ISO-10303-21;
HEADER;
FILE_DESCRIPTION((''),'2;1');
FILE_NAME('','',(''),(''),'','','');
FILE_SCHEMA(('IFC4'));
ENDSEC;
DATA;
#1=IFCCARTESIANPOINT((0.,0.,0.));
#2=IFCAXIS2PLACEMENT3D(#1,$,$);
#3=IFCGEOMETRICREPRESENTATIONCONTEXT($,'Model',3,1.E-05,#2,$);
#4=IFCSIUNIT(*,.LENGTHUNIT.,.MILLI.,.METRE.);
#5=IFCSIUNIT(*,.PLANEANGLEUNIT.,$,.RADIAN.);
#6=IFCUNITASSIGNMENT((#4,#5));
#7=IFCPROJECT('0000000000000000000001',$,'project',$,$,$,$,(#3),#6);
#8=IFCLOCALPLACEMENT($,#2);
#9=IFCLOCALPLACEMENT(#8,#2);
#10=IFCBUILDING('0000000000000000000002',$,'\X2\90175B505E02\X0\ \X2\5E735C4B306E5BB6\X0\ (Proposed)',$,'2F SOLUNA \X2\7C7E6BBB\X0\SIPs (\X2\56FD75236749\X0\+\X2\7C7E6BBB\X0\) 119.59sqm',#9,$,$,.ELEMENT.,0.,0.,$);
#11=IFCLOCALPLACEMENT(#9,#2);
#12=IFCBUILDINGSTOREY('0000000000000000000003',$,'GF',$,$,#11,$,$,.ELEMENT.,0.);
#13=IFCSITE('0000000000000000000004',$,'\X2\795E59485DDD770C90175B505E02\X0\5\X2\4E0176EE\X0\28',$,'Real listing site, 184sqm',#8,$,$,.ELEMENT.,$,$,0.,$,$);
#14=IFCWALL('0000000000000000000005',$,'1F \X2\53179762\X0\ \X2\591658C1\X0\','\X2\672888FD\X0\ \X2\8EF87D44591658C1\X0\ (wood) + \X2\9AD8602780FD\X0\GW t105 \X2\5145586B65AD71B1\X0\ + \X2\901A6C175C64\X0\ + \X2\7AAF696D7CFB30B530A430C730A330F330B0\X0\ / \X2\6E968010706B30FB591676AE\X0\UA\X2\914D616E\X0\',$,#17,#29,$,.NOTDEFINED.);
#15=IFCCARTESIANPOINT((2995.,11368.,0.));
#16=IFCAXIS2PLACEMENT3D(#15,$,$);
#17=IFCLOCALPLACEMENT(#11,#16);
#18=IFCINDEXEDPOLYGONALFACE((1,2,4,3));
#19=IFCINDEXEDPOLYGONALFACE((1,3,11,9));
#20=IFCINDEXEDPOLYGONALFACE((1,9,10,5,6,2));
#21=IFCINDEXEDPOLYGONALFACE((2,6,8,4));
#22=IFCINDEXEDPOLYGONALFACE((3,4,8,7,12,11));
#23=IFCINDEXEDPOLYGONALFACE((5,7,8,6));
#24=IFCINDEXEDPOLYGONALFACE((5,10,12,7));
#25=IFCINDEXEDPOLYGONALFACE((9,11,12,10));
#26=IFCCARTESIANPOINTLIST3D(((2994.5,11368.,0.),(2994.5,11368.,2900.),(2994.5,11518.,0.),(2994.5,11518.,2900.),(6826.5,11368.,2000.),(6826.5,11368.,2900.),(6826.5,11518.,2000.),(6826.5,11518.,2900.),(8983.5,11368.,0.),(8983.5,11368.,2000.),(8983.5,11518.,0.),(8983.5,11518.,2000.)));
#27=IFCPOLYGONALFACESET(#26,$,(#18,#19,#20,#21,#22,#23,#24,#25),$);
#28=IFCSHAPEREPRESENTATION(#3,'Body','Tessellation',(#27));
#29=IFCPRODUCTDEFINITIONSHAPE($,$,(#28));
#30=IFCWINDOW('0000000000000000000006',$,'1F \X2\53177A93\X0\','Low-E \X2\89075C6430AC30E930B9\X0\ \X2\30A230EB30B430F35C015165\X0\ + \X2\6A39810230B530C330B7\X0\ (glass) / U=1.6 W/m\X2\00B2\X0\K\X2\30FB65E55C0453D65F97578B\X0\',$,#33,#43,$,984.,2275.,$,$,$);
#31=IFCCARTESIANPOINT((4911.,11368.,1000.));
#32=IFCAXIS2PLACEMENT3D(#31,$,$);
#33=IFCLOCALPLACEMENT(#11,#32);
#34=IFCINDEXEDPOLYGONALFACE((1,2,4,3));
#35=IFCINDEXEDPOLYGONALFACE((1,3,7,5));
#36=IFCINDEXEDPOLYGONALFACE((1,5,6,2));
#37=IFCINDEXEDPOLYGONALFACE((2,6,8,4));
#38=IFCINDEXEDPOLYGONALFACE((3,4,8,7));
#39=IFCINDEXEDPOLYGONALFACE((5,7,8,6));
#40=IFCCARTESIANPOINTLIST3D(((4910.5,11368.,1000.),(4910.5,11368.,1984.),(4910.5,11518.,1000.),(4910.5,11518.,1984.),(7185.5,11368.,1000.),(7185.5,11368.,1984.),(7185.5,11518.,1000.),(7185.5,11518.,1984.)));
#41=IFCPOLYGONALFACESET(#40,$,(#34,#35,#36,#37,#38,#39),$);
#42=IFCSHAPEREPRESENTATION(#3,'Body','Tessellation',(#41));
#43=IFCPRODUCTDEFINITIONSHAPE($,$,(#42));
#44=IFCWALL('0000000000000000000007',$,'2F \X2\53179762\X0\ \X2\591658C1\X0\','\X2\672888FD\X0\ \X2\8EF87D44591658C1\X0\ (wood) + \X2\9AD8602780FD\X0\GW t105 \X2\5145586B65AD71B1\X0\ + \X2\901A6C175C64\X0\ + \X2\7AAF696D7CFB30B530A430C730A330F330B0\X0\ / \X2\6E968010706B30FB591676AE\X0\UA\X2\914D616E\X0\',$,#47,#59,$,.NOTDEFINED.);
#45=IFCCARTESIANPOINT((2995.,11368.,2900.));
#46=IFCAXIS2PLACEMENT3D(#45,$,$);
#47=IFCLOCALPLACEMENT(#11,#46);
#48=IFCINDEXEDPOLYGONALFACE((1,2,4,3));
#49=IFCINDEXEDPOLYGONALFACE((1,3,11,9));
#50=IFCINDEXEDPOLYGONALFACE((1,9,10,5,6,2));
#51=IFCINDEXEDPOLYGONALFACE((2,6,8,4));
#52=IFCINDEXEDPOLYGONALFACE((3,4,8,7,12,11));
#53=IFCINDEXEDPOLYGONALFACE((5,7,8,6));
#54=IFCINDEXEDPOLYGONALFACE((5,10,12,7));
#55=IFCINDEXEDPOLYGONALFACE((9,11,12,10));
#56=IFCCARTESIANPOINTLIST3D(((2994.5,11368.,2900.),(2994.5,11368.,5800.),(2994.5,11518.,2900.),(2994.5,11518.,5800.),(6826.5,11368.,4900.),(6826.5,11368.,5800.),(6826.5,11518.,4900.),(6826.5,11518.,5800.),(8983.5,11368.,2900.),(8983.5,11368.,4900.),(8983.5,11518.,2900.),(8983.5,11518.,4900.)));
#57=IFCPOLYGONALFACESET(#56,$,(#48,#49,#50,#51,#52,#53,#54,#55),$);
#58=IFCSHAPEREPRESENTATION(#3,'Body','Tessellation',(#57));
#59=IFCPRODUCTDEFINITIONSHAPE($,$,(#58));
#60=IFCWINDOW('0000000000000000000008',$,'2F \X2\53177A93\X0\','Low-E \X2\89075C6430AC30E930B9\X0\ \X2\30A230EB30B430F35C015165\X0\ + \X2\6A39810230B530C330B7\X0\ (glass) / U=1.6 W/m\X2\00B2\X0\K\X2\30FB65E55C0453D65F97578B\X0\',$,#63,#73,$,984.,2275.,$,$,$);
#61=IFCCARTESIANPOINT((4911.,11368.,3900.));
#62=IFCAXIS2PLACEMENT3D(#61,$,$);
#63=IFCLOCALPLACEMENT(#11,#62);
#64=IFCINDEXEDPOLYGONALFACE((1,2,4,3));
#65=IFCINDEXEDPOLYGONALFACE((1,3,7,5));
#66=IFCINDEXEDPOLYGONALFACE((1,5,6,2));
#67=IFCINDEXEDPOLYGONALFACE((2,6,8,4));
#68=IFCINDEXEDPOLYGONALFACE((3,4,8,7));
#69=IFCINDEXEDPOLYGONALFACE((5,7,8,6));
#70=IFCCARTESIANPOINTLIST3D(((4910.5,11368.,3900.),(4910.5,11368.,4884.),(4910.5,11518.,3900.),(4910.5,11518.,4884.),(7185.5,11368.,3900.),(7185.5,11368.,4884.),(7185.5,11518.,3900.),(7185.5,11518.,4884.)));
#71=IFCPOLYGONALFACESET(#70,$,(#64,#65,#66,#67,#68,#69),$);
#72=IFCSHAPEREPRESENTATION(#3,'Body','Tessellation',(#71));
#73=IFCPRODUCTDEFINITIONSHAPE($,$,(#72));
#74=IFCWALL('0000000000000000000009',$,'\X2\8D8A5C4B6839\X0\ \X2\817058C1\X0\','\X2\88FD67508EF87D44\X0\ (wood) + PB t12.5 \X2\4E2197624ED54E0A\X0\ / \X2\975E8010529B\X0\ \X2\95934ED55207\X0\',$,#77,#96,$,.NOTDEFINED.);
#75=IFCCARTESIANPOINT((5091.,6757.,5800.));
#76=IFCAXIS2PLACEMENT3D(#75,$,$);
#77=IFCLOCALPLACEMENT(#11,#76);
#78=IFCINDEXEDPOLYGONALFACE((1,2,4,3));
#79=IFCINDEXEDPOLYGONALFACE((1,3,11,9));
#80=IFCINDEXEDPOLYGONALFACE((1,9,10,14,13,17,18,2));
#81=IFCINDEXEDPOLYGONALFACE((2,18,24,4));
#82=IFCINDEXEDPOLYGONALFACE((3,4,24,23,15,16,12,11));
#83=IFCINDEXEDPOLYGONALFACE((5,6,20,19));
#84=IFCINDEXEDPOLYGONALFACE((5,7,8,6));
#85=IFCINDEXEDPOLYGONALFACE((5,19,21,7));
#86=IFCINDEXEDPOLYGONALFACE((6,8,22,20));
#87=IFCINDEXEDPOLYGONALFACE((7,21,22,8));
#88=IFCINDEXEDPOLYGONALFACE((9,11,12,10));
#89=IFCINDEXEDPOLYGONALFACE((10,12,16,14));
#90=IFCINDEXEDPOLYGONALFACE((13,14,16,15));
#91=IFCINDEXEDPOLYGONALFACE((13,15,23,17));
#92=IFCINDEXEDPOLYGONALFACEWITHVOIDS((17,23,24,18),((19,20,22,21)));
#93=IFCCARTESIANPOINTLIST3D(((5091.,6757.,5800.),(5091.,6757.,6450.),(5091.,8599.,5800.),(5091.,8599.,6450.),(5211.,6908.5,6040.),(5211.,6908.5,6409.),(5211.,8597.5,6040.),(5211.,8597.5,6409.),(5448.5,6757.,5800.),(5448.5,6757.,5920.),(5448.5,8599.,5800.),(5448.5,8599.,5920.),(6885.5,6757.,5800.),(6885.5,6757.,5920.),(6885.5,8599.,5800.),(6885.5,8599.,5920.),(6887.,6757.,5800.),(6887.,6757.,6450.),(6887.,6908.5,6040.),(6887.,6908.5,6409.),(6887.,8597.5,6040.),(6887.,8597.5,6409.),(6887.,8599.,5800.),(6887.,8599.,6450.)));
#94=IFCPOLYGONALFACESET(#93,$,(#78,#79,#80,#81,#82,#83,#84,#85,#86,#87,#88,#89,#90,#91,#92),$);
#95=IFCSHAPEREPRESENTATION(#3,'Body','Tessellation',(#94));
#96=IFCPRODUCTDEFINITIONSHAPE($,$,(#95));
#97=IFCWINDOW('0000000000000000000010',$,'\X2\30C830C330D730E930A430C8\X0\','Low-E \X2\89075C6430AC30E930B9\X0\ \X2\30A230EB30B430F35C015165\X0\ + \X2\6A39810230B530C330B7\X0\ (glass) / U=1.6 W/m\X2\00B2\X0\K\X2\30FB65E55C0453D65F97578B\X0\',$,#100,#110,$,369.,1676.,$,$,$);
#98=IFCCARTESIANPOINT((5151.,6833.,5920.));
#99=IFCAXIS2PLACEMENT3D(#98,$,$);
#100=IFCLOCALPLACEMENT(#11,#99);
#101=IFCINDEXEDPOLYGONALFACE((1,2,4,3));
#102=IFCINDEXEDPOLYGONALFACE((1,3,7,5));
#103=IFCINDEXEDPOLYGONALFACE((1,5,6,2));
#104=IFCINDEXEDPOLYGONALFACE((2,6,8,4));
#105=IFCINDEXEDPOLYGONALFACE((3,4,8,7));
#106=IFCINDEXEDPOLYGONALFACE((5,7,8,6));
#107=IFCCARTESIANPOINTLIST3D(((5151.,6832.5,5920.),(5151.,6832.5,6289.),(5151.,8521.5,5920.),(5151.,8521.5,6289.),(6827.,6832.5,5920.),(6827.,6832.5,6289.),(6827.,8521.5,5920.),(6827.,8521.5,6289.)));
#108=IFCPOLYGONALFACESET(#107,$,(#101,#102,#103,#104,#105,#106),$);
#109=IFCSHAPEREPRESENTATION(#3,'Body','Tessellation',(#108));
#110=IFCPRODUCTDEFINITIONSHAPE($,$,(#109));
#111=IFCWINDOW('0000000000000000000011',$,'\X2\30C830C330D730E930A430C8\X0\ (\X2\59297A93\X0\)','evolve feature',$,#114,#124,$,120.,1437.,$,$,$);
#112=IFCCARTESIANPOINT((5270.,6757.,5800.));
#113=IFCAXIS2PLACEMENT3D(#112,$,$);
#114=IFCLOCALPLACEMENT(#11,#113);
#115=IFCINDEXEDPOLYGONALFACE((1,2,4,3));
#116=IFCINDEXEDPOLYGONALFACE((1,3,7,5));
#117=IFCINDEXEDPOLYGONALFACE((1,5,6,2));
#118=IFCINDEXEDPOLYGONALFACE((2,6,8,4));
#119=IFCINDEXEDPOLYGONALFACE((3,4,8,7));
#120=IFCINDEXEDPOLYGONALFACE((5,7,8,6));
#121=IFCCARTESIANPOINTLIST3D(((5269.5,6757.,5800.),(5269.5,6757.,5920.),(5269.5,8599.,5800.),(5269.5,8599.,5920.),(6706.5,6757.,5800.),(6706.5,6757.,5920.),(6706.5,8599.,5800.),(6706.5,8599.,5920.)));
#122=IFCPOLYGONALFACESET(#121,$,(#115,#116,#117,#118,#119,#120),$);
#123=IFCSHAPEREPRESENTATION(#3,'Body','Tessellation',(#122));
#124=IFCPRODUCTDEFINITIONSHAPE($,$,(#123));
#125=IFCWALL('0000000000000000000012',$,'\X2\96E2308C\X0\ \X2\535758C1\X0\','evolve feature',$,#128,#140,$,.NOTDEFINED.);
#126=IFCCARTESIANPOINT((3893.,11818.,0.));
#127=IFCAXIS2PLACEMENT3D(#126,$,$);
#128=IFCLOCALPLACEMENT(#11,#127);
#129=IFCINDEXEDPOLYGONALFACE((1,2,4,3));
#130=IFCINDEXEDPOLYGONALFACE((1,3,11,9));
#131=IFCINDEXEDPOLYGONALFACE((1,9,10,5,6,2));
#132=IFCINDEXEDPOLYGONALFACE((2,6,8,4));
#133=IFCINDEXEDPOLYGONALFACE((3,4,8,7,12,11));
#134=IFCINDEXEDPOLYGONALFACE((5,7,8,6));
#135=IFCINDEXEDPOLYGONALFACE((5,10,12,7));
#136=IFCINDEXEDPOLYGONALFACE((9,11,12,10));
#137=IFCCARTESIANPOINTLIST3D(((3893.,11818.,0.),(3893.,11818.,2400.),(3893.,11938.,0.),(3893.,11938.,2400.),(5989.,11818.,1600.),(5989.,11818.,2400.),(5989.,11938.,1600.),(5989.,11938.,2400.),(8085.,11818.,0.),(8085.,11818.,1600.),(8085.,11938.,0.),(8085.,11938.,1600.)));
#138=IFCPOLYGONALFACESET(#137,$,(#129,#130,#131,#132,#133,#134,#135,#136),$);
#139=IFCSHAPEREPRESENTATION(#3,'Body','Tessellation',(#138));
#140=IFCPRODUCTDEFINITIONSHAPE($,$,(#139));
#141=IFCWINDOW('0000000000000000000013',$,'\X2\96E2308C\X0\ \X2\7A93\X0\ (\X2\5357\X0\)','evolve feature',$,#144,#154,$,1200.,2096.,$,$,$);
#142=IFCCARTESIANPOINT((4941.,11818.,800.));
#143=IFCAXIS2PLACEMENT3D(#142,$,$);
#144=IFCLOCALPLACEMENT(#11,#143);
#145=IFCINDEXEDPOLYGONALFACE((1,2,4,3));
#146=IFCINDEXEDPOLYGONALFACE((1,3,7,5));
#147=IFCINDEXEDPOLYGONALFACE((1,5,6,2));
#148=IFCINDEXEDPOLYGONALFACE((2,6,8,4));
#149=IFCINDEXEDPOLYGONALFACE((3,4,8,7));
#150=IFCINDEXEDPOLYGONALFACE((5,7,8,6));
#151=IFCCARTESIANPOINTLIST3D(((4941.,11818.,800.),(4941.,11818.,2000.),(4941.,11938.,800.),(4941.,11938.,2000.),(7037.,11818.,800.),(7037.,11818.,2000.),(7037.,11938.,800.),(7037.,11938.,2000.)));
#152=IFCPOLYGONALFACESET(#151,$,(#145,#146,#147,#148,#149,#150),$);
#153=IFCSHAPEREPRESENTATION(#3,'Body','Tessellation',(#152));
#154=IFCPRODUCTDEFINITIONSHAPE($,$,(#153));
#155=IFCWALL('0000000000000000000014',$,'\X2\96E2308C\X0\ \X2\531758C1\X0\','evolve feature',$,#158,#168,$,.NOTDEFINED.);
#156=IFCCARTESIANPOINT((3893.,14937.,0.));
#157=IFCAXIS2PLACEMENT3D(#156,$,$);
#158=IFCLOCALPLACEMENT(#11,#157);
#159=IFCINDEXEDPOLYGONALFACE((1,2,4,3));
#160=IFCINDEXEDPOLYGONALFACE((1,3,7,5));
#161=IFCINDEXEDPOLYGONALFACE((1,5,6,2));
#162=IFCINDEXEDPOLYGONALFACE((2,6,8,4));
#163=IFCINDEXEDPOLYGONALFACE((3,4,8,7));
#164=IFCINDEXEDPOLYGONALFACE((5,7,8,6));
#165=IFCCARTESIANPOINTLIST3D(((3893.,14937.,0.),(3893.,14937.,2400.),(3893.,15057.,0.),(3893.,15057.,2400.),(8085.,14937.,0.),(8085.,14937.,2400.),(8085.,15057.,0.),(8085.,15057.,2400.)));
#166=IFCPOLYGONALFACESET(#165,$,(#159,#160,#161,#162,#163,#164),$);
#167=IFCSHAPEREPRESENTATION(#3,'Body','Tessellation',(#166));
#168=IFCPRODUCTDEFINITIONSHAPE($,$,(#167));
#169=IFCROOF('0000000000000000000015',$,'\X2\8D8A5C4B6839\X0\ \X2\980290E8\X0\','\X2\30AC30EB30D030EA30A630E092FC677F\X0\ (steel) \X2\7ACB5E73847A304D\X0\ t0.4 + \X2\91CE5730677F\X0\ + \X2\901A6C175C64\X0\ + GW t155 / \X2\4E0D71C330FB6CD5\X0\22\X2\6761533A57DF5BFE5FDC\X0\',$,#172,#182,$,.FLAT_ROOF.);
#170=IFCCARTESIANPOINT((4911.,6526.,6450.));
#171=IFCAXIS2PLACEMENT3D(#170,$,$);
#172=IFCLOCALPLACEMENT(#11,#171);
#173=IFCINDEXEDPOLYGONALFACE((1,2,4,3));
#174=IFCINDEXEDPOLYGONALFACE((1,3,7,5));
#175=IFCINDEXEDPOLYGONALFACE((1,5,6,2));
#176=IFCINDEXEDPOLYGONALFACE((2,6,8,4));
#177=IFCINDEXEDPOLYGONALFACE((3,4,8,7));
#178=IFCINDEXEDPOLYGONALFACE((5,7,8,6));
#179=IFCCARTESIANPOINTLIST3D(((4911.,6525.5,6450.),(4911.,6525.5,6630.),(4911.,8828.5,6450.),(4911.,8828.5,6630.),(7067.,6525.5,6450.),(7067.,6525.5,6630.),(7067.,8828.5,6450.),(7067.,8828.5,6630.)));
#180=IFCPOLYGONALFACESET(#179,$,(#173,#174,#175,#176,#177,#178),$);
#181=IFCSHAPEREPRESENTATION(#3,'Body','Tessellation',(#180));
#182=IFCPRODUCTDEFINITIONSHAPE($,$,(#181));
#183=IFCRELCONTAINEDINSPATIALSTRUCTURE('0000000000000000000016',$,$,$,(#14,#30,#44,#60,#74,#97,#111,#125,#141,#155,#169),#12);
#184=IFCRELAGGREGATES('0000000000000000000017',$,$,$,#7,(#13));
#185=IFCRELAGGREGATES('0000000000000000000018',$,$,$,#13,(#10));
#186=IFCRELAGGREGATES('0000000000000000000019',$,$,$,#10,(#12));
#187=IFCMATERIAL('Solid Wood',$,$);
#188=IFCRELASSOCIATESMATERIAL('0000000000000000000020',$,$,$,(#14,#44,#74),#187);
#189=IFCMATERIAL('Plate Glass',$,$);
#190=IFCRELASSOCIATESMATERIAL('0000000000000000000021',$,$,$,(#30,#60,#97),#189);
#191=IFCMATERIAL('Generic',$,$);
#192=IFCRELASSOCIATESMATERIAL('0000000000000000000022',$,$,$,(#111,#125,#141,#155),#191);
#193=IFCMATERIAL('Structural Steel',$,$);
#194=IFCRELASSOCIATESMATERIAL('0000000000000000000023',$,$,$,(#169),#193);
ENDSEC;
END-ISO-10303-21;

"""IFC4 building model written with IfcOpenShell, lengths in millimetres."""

from ifc_helpers import new_model, si_unit, frame, frame_2d, origin, place, context, project, spatial, rectangle, extrude, material, element, fill, save


model = new_model("IFC4")

# Units and contexts
model_context = context("Model", 3, precision=1e-05, world=origin())
ifc_project = project(units=[si_unit("LENGTHUNIT", "METRE", prefix="MILLI"), si_unit("PLANEANGLEUNIT", "RADIAN")], contexts=[model_context])

# Site, building, storey
site_placement = place(None, origin())
site = spatial("IfcSite", under=ifc_project, at=site_placement, Name="神奈川県逗子市5丁目28", ObjectType="Real listing site, 184sqm", CompositionType="ELEMENT", RefElevation=0.0)
building_placement = place(site_placement, origin())
building = spatial("IfcBuilding", under=site, at=building_placement, Name="逗子市 平屋の家 (Proposed)", ObjectType="2F SOLUNA 籾殻SIPs (国産杉+籾殻) 119.59sqm", CompositionType="ELEMENT", ElevationOfRefHeight=0.0, ElevationOfTerrain=0.0)
storey_placement = place(building_placement, origin())
storey = spatial("IfcBuildingStorey", under=building, at=storey_placement, Name="GF", CompositionType="ELEMENT", Elevation=0.0)

# Shared definitions
ifc_material_1 = material(Name="Generic")

# Wall, opening, window
ifc_material_2 = material(Name="Solid Wood")
wall_1_placement = place(storey_placement, frame((2995.0, 11368.0, 0.0)))
wall_1 = element("IfcWall", 1, at=wall_1_placement, inside=storey, material=ifc_material_2, Name="1F 北面 外壁", Description="木製 軸組外壁 (wood) + 高性能GW t105 充填断熱 + 通気層 + 窯業系サイディング / 準耐火・外皮UA配慮", PredefinedType="NOTDEFINED", context=model_context, shape_type="SweptSolid", body=[
    extrude(rectangle(XDim=5989.0, YDim=150.0, at=frame_2d((2994.0, 75.0))), frame((2995.0, 11368.0, 0.0)), (0.0, 0.0, 1.0), 2900.0),
])
opening_1_placement = place(storey_placement, frame((4911.0, 11368.0, 1000.0)))
opening_1 = element("IfcOpeningElement", 2, at=opening_1_placement, cuts=wall_1, PredefinedType="NOTDEFINED", context=model_context, shape_type="SweptSolid", body=[
    extrude(rectangle(XDim=2275.0, YDim=150.0, at=frame_2d((1137.0, 75.0))), frame((4911.0, 11368.0, 1000.0)), (0.0, 0.0, 1.0), 984.0),
])
ifc_material_3 = material(Name="Plate Glass")
window_1_placement = place(storey_placement, frame((4911.0, 11368.0, 1000.0)))
window_1 = element("IfcWindow", 3, at=window_1_placement, inside=storey, material=ifc_material_3, Name="1F 北窓", Description="Low-E 複層ガラス アルゴン封入 + 樹脂サッシ (glass) / U=1.6 W/m²K・日射取得型", OverallHeight=984.0, OverallWidth=2275.0, context=model_context, shape_type="SweptSolid", body=[
    extrude(rectangle(XDim=2275.0, YDim=150.0, at=frame_2d((1137.0, 75.0))), frame((4911.0, 11368.0, 1000.0)), (0.0, 0.0, 1.0), 984.0),
])
fill(opening_1, window_1)

# Wall, opening, window
wall_2_placement = place(storey_placement, frame((2995.0, 11368.0, 2900.0)))
wall_2 = element("IfcWall", 4, at=wall_2_placement, inside=storey, material=ifc_material_2, Name="2F 北面 外壁", Description="木製 軸組外壁 (wood) + 高性能GW t105 充填断熱 + 通気層 + 窯業系サイディング / 準耐火・外皮UA配慮", PredefinedType="NOTDEFINED", context=model_context, shape_type="SweptSolid", body=[
    extrude(rectangle(XDim=5989.0, YDim=150.0, at=frame_2d((2994.0, 75.0))), frame((2995.0, 11368.0, 2900.0)), (0.0, 0.0, 1.0), 2900.0),
])
opening_2_placement = place(storey_placement, frame((4911.0, 11368.0, 3900.0)))
opening_2 = element("IfcOpeningElement", 5, at=opening_2_placement, cuts=wall_2, PredefinedType="NOTDEFINED", context=model_context, shape_type="SweptSolid", body=[
    extrude(rectangle(XDim=2275.0, YDim=150.0, at=frame_2d((1137.0, 75.0))), frame((4911.0, 11368.0, 3900.0)), (0.0, 0.0, 1.0), 984.0),
])
window_2_placement = place(storey_placement, frame((4911.0, 11368.0, 3900.0)))
window_2 = element("IfcWindow", 6, at=window_2_placement, inside=storey, material=ifc_material_3, Name="2F 北窓", Description="Low-E 複層ガラス アルゴン封入 + 樹脂サッシ (glass) / U=1.6 W/m²K・日射取得型", OverallHeight=984.0, OverallWidth=2275.0, context=model_context, shape_type="SweptSolid", body=[
    extrude(rectangle(XDim=2275.0, YDim=150.0, at=frame_2d((1137.0, 75.0))), frame((4911.0, 11368.0, 3900.0)), (0.0, 0.0, 1.0), 984.0),
])
fill(opening_2, window_2)

# Wall, openings, windows
wall_3_placement = place(storey_placement, frame((5091.0, 6757.0, 5800.0)))
wall_3 = element("IfcWall", 7, at=wall_3_placement, inside=storey, material=ifc_material_2, Name="越屋根 腰壁", Description="製材軸組 (wood) + PB t12.5 両面仕上 / 非耐力 間仕切", PredefinedType="NOTDEFINED", context=model_context, shape_type="SweptSolid", body=[
    extrude(rectangle(XDim=1796.0, YDim=1842.0, at=frame_2d((898.0, 921.0))), frame((5091.0, 6757.0, 5800.0)), (0.0, 0.0, 1.0), 650.0),
])
opening_3_placement = place(storey_placement, frame((5151.0, 6833.0, 5920.0)))
opening_3 = element("IfcOpeningElement", 8, at=opening_3_placement, cuts=wall_3, PredefinedType="NOTDEFINED", context=model_context, shape_type="SweptSolid", body=[
    extrude(rectangle(XDim=1676.0, YDim=1689.0, at=frame_2d((838.0, 844.0))), frame((5151.0, 6833.0, 5920.0)), (0.0, 0.0, 1.0), 369.0),
])
opening_4_placement = place(storey_placement, frame((5270.0, 6757.0, 5800.0)))
opening_4 = element("IfcOpeningElement", 9, at=opening_4_placement, cuts=wall_3, PredefinedType="NOTDEFINED", context=model_context, shape_type="SweptSolid", body=[
    extrude(rectangle(XDim=1437.0, YDim=1842.0, at=frame_2d((718.0, 921.0))), frame((5270.0, 6757.0, 5800.0)), (0.0, 0.0, 1.0), 120.0),
])
window_3_placement = place(storey_placement, frame((5151.0, 6833.0, 5920.0)))
window_3 = element("IfcWindow", 10, at=window_3_placement, inside=storey, material=ifc_material_3, Name="トップライト", Description="Low-E 複層ガラス アルゴン封入 + 樹脂サッシ (glass) / U=1.6 W/m²K・日射取得型", OverallHeight=369.0, OverallWidth=1676.0, context=model_context, shape_type="SweptSolid", body=[
    extrude(rectangle(XDim=1676.0, YDim=1689.0, at=frame_2d((838.0, 844.0))), frame((5151.0, 6833.0, 5920.0)), (0.0, 0.0, 1.0), 369.0),
])
fill(opening_3, window_3)
window_4_placement = place(storey_placement, frame((5270.0, 6757.0, 5800.0)))
window_4 = element("IfcWindow", 11, at=window_4_placement, inside=storey, material=ifc_material_1, Name="トップライト (天窓)", Description="evolve feature", OverallHeight=120.0, OverallWidth=1437.0, context=model_context, shape_type="SweptSolid", body=[
    extrude(rectangle(XDim=1437.0, YDim=1842.0, at=frame_2d((718.0, 921.0))), frame((5270.0, 6757.0, 5800.0)), (0.0, 0.0, 1.0), 120.0),
])
fill(opening_4, window_4)

# Wall, opening, window
wall_4_placement = place(storey_placement, frame((3893.0, 11818.0, 0.0)))
wall_4 = element("IfcWall", 12, at=wall_4_placement, inside=storey, material=ifc_material_1, Name="離れ 南壁", Description="evolve feature", PredefinedType="NOTDEFINED", context=model_context, shape_type="SweptSolid", body=[
    extrude(rectangle(XDim=4192.0, YDim=120.0, at=frame_2d((2096.0, 60.0))), frame((3893.0, 11818.0, 0.0)), (0.0, 0.0, 1.0), 2400.0),
])
opening_5_placement = place(storey_placement, frame((4941.0, 11818.0, 800.0)))
opening_5 = element("IfcOpeningElement", 13, at=opening_5_placement, cuts=wall_4, PredefinedType="NOTDEFINED", context=model_context, shape_type="SweptSolid", body=[
    extrude(rectangle(XDim=2096.0, YDim=120.0, at=frame_2d((1048.0, 60.0))), frame((4941.0, 11818.0, 800.0)), (0.0, 0.0, 1.0), 1200.0),
])
window_5_placement = place(storey_placement, frame((4941.0, 11818.0, 800.0)))
window_5 = element("IfcWindow", 14, at=window_5_placement, inside=storey, material=ifc_material_1, Name="離れ 窓 (南)", Description="evolve feature", OverallHeight=1200.0, OverallWidth=2096.0, context=model_context, shape_type="SweptSolid", body=[
    extrude(rectangle(XDim=2096.0, YDim=120.0, at=frame_2d((1048.0, 60.0))), frame((4941.0, 11818.0, 800.0)), (0.0, 0.0, 1.0), 1200.0),
])
fill(opening_5, window_5)

# Wall
wall_5_placement = place(storey_placement, frame((3893.0, 14937.0, 0.0)))
element("IfcWall", 15, at=wall_5_placement, inside=storey, material=ifc_material_1, Name="離れ 北壁", Description="evolve feature", PredefinedType="NOTDEFINED", context=model_context, shape_type="SweptSolid", body=[
    extrude(rectangle(XDim=4192.0, YDim=120.0, at=frame_2d((2096.0, 60.0))), frame((3893.0, 14937.0, 0.0)), (0.0, 0.0, 1.0), 2400.0),
])

# Roof
ifc_material_4 = material(Name="Structural Steel")
roof_1_placement = place(storey_placement, frame((4911.0, 6526.0, 6450.0)))
element("IfcRoof", 16, at=roof_1_placement, inside=storey, material=ifc_material_4, Name="越屋根 頂部", Description="ガルバリウム鋼板 (steel) 立平葺き t0.4 + 野地板 + 通気層 + GW t155 / 不燃・法22条区域対応", PredefinedType="FLAT_ROOF", context=model_context, shape_type="SweptSolid", body=[
    extrude(rectangle(XDim=2156.0, YDim=2303.0, at=frame_2d((1078.0, 1151.0))), frame((4911.0, 6526.0, 6450.0)), (0.0, 0.0, 1.0), 180.0),
])

save(model, "model.ifc")
